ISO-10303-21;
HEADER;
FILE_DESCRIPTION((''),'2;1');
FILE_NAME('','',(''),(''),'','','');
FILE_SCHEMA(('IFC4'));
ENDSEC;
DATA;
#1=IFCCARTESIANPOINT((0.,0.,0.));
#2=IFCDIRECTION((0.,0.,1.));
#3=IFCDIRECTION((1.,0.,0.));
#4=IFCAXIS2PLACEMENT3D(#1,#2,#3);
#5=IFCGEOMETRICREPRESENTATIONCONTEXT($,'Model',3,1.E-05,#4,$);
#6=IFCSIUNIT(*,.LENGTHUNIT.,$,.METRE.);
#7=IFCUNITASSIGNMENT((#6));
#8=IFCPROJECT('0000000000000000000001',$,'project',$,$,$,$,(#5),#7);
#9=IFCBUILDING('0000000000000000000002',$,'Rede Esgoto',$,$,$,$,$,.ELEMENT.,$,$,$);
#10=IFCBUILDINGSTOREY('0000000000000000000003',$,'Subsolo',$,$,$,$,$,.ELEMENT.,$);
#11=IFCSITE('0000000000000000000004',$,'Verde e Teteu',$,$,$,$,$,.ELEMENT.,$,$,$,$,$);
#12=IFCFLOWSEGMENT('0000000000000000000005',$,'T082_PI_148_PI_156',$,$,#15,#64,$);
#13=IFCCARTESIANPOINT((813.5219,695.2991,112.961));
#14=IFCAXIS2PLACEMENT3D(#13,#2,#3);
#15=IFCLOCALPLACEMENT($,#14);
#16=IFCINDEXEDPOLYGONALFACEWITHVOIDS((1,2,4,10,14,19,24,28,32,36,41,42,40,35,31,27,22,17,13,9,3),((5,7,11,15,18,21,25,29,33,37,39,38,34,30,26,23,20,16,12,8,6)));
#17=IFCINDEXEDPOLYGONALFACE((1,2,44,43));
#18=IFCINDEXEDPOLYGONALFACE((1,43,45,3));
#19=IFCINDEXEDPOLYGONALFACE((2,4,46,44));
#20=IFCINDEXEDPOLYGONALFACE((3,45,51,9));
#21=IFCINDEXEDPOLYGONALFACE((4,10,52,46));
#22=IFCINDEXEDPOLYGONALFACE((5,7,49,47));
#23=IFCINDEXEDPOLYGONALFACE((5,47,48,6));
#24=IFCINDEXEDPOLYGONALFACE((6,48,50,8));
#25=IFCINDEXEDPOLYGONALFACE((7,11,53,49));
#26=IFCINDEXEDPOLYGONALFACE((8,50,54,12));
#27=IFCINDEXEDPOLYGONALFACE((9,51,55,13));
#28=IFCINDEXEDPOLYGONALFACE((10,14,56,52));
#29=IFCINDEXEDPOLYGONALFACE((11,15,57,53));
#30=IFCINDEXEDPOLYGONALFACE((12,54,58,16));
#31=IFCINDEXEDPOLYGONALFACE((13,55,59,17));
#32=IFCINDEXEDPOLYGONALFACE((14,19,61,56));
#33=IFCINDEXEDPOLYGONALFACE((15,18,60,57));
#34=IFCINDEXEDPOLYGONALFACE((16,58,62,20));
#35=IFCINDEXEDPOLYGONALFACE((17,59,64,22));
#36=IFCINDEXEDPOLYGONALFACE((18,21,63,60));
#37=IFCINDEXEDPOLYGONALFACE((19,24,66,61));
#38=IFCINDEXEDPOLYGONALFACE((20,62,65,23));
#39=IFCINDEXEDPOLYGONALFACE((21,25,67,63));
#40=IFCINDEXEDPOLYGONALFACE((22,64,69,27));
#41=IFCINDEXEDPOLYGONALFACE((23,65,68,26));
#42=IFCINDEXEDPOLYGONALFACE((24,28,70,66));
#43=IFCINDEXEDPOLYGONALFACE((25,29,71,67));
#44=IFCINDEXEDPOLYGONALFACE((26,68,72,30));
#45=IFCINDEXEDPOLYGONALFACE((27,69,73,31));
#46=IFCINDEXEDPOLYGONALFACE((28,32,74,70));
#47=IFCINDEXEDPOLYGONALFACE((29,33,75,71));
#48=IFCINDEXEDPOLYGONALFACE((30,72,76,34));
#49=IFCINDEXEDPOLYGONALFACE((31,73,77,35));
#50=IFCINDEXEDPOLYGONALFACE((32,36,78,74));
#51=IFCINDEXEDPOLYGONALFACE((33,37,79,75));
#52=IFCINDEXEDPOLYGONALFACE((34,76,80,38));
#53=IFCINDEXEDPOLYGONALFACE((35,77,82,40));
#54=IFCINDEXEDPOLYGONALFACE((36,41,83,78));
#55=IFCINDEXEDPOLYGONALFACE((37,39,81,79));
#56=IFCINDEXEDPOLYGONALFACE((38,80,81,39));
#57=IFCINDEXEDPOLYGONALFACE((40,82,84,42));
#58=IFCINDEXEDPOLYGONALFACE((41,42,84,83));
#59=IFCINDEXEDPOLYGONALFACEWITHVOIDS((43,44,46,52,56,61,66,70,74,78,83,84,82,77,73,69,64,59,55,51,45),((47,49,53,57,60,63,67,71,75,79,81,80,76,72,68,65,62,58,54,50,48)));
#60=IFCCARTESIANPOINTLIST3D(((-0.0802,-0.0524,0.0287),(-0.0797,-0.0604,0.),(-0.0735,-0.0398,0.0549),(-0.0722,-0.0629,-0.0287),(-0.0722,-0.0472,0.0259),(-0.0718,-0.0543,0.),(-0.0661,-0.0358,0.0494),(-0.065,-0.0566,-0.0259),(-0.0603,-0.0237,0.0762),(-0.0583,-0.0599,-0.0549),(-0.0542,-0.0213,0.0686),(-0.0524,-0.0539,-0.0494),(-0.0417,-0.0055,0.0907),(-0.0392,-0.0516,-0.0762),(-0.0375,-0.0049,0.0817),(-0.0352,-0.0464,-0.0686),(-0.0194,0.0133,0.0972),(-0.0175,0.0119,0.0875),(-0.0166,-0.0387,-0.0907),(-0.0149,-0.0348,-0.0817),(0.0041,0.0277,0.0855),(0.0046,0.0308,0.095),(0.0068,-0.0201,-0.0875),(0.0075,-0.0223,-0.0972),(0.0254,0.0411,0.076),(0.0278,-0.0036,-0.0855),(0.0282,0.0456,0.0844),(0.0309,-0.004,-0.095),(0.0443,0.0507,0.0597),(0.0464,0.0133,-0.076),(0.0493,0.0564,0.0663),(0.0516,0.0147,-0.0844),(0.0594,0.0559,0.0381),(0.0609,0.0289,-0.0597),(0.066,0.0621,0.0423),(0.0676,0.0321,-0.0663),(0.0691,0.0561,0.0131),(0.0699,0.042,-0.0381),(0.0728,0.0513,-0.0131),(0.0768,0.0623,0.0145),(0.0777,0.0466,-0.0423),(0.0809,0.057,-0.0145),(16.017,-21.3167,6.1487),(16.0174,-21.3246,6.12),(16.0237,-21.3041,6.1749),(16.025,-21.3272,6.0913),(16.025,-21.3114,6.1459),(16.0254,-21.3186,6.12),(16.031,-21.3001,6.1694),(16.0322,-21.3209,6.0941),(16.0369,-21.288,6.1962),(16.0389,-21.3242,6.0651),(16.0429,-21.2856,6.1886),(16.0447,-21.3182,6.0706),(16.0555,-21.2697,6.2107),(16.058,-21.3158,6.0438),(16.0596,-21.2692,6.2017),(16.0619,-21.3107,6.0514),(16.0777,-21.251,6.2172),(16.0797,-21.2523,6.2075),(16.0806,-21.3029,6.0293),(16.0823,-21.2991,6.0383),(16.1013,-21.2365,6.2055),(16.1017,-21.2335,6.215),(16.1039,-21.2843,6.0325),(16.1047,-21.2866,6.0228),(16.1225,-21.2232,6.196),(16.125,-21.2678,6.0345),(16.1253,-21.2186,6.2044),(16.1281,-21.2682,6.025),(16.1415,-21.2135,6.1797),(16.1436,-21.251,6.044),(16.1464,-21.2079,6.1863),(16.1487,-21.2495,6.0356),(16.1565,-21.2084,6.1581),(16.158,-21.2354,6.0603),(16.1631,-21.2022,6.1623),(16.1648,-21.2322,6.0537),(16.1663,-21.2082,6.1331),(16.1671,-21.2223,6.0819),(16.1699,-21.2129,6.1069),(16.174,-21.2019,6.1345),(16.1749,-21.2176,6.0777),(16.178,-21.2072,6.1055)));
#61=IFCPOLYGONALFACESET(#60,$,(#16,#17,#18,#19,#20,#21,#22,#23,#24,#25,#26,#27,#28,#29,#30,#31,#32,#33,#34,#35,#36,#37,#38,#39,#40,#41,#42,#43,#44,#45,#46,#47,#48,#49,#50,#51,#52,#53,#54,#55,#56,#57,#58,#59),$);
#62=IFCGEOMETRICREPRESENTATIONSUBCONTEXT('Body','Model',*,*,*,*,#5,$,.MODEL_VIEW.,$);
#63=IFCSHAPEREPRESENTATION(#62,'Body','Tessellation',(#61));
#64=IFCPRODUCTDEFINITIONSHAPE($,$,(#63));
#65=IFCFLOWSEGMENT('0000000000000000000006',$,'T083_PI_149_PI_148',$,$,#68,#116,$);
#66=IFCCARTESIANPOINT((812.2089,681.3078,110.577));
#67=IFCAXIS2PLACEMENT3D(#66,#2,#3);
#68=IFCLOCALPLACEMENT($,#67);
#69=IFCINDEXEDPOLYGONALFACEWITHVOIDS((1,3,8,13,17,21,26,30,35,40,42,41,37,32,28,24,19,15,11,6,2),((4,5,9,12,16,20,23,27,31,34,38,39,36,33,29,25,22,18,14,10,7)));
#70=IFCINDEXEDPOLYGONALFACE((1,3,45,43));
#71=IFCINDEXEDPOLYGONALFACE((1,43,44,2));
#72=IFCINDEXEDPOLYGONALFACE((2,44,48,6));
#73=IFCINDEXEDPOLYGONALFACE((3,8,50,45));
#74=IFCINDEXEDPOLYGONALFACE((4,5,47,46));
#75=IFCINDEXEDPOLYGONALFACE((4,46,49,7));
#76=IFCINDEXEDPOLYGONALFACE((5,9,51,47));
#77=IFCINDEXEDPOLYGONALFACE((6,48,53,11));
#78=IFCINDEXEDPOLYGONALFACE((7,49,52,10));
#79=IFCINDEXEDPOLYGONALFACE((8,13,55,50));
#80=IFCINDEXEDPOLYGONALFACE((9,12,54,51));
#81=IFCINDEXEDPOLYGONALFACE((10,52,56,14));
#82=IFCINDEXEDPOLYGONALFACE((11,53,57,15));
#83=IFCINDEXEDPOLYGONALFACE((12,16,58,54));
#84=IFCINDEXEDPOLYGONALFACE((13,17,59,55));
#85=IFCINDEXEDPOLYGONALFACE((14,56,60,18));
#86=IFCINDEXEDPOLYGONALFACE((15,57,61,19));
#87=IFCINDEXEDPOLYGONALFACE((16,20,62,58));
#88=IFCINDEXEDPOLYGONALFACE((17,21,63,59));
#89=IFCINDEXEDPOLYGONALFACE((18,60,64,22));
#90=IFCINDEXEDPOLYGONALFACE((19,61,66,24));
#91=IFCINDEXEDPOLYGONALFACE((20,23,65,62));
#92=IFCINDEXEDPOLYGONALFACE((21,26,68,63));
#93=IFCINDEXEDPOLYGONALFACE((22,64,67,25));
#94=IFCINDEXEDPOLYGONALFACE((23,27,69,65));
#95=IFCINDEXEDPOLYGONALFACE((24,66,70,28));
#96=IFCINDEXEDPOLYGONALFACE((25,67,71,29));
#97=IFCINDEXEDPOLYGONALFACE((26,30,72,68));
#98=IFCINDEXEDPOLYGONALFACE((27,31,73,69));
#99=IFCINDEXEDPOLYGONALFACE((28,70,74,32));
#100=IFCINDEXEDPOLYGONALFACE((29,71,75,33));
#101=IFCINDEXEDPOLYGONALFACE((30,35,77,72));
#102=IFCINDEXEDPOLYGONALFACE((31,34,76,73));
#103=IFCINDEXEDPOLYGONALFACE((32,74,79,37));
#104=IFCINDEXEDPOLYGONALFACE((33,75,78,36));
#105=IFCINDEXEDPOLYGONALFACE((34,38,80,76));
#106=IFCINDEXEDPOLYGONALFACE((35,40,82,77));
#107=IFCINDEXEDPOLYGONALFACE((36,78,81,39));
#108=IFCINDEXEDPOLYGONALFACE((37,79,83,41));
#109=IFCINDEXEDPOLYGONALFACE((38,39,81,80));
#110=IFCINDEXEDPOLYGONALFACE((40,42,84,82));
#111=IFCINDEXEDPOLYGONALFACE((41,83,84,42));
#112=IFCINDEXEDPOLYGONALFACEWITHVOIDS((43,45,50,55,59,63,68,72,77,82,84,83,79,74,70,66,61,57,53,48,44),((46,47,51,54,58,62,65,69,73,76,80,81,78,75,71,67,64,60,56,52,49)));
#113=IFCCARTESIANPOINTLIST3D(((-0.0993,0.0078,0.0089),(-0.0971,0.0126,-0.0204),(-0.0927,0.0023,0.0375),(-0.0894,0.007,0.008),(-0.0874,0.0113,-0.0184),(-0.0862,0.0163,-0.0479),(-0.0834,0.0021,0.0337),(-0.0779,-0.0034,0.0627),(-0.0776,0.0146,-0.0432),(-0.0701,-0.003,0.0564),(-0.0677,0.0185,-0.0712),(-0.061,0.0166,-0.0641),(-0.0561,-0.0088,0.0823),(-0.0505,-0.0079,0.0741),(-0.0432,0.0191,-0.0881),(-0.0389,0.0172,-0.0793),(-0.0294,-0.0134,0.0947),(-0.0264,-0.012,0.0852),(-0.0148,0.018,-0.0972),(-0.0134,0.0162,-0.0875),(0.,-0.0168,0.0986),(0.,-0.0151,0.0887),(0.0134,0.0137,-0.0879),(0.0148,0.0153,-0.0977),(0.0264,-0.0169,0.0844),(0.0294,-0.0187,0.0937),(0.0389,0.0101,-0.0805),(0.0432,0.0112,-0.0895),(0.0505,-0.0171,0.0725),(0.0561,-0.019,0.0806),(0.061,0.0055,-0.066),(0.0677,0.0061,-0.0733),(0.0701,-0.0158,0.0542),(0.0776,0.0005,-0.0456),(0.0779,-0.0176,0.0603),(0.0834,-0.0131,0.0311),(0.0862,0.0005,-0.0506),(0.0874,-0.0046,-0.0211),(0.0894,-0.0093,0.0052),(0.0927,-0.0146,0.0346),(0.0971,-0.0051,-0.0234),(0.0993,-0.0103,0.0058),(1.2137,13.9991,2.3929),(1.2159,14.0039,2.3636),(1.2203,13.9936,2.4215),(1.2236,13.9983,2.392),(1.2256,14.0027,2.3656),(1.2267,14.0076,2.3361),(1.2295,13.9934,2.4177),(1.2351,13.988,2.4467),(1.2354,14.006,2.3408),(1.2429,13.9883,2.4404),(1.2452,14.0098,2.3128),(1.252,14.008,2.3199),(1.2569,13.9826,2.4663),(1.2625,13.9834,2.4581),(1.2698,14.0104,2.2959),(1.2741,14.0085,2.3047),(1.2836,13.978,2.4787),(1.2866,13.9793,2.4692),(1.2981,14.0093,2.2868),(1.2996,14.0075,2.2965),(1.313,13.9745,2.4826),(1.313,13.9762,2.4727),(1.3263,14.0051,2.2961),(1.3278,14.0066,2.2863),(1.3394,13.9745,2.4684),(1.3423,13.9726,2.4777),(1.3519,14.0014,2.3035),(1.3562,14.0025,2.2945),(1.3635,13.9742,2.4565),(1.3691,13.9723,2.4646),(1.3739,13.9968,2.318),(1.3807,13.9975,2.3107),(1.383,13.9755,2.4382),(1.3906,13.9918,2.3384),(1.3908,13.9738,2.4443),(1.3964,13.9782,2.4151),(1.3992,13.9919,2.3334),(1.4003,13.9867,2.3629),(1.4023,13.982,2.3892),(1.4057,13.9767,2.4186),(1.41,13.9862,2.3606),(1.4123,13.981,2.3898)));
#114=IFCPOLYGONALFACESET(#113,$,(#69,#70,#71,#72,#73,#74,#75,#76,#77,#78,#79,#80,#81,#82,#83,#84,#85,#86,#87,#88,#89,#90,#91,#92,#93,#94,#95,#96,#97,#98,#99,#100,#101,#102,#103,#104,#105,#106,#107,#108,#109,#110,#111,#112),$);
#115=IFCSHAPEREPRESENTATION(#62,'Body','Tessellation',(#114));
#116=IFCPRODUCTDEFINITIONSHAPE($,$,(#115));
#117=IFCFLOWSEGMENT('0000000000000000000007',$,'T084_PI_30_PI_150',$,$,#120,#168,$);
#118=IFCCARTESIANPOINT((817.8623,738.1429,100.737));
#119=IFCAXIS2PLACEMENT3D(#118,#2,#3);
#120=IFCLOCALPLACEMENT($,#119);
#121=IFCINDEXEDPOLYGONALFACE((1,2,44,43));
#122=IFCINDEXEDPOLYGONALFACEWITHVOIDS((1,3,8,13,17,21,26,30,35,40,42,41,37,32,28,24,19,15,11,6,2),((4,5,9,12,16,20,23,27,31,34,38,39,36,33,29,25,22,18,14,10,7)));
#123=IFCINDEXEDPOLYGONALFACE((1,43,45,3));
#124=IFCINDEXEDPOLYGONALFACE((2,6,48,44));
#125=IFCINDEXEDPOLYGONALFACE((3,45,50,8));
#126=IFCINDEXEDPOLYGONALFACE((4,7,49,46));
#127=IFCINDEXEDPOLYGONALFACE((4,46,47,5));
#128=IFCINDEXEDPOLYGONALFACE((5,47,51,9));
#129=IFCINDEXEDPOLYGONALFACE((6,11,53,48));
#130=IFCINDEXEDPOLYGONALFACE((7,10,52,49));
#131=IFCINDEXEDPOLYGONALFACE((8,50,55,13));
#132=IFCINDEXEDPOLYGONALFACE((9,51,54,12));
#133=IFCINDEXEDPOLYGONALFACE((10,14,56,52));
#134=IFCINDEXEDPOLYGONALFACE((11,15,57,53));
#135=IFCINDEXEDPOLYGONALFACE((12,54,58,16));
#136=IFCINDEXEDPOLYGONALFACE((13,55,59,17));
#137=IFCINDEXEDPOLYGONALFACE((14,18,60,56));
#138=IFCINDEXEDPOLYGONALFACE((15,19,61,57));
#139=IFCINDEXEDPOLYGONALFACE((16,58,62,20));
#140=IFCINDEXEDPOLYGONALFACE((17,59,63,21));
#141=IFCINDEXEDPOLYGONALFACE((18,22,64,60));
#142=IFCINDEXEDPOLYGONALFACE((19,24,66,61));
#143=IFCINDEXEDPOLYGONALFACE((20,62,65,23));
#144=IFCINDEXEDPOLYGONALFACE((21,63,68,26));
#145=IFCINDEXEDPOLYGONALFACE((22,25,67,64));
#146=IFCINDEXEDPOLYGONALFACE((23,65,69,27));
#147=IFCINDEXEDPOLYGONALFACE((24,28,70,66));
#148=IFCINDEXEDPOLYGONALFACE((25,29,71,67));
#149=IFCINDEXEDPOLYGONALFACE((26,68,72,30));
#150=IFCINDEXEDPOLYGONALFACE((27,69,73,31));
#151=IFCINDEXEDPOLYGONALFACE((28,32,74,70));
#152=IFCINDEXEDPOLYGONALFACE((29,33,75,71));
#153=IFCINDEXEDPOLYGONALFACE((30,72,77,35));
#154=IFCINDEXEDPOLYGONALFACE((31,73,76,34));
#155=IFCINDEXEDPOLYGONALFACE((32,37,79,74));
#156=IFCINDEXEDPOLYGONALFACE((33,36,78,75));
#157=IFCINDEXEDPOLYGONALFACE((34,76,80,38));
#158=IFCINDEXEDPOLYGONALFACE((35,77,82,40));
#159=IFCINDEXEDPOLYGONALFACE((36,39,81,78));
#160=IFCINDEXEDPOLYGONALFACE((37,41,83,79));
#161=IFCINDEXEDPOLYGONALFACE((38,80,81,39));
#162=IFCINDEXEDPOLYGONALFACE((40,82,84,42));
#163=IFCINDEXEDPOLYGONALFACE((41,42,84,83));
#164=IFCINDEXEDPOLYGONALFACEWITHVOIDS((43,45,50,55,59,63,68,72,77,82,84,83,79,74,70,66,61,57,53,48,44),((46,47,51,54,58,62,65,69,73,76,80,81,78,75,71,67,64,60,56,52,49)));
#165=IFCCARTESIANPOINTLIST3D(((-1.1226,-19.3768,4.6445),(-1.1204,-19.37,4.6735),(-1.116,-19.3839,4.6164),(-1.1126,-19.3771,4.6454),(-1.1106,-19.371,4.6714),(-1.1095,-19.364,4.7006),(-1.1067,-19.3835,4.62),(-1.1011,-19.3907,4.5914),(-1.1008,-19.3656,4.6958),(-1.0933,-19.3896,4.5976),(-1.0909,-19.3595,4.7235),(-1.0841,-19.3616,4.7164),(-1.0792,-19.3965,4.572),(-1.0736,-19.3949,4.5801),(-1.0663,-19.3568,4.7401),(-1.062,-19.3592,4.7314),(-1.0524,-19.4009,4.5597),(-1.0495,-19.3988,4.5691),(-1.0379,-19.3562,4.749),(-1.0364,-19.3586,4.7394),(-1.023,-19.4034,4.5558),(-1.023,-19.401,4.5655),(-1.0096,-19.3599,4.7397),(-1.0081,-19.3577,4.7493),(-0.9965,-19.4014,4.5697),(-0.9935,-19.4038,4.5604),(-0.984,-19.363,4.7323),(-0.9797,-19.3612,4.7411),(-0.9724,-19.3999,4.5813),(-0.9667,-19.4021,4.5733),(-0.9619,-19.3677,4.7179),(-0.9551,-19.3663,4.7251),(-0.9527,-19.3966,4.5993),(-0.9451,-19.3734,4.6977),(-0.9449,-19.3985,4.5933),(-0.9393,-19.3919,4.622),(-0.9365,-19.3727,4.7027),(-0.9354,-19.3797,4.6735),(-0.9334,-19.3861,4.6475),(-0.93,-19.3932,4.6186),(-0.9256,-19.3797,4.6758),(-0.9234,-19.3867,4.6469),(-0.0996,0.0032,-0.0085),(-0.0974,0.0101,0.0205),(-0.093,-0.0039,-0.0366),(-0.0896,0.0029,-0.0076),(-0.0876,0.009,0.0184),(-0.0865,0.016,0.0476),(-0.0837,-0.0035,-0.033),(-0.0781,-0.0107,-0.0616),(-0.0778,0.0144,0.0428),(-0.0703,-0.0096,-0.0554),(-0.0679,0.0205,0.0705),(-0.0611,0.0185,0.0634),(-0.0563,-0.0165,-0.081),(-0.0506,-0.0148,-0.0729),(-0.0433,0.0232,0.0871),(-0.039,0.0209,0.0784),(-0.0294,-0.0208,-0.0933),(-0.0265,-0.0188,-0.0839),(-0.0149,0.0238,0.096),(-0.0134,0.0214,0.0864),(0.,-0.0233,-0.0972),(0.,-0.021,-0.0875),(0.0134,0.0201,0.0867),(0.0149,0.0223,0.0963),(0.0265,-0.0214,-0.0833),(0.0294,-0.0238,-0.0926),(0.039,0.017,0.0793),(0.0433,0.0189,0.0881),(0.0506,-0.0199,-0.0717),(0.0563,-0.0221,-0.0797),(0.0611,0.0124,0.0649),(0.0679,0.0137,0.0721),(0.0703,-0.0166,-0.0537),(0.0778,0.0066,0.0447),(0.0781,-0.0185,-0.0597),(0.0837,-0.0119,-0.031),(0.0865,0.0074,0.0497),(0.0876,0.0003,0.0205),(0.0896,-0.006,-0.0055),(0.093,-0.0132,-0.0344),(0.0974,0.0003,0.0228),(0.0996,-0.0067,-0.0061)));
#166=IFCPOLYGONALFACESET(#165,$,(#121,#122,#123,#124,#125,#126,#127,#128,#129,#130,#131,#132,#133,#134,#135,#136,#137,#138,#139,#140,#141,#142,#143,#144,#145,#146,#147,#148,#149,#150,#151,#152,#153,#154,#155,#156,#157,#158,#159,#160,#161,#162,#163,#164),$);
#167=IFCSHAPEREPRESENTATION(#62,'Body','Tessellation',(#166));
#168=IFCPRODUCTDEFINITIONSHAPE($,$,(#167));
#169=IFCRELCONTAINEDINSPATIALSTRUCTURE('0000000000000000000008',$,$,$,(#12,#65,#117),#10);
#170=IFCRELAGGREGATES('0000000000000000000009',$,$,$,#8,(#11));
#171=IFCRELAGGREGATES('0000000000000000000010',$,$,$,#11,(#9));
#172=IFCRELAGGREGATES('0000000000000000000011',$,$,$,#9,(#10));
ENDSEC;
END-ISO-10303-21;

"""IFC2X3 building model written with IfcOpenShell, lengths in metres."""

from ifc_helpers import new_model, entity, si_unit, frame, origin_with_axes, place, context, subcontext, project, spatial, element, save


model = new_model("IFC2X3")

# Units and contexts
model_context = context("Model", 3, precision=1e-05, world=origin_with_axes())
body_context = subcontext(model_context, "Body", "Model", "MODEL_VIEW")
ifc_project = project(units=[si_unit("LENGTHUNIT", "METRE")], contexts=[model_context])

# Site, building, storey
site = spatial("IfcSite", under=ifc_project, Name="Verde e Teteu", CompositionType="ELEMENT")
building = spatial("IfcBuilding", under=site, Name="Rede Esgoto", CompositionType="ELEMENT")
storey = spatial("IfcBuildingStorey", under=building, Name="Subsolo", CompositionType="ELEMENT")

# Flow segments
flow_segment_1_placement = place(None, frame((813.5219, 695.2991, 112.961), z_axis=(0.0, 0.0, 1.0), x_axis=(1.0, 0.0, 0.0)))
element("IfcFlowSegment", 1, at=flow_segment_1_placement, inside=storey, Name="T082_PI_148_PI_156", context=body_context, shape_type="SweptSolid", body=[
    entity("IfcSweptDiskSolid", entity("IfcPolyline", [entity("IfcCartesianPoint", [0.0, 0.0, 0.0]), entity("IfcCartesianPoint", [16.0972, -21.2643, 6.12])]), 0.1, 0.09),
])
flow_segment_2_placement = place(None, frame((812.2089, 681.3078, 110.577), z_axis=(0.0, 0.0, 1.0), x_axis=(1.0, 0.0, 0.0)))
element("IfcFlowSegment", 2, at=flow_segment_2_placement, inside=storey, Name="T083_PI_149_PI_148", context=body_context, shape_type="SweptSolid", body=[
    entity("IfcSweptDiskSolid", entity("IfcPolyline", [entity("IfcCartesianPoint", [0.0, 0.0, 0.0]), entity("IfcCartesianPoint", [1.313, 13.9913, 2.384])]), 0.1, 0.09),
])
flow_segment_3_placement = place(None, frame((817.8623, 738.1429, 100.737), z_axis=(0.0, 0.0, 1.0), x_axis=(1.0, 0.0, 0.0)))
element("IfcFlowSegment", 3, at=flow_segment_3_placement, inside=storey, Name="T084_PI_30_PI_150", context=body_context, shape_type="SweptSolid", body=[
    entity("IfcSweptDiskSolid", entity("IfcPolyline", [entity("IfcCartesianPoint", [0.0, 0.0, 0.0]), entity("IfcCartesianPoint", [-1.023, -19.38, 4.653])]), 0.1, 0.09),
])

save(model, "model.ifc")
